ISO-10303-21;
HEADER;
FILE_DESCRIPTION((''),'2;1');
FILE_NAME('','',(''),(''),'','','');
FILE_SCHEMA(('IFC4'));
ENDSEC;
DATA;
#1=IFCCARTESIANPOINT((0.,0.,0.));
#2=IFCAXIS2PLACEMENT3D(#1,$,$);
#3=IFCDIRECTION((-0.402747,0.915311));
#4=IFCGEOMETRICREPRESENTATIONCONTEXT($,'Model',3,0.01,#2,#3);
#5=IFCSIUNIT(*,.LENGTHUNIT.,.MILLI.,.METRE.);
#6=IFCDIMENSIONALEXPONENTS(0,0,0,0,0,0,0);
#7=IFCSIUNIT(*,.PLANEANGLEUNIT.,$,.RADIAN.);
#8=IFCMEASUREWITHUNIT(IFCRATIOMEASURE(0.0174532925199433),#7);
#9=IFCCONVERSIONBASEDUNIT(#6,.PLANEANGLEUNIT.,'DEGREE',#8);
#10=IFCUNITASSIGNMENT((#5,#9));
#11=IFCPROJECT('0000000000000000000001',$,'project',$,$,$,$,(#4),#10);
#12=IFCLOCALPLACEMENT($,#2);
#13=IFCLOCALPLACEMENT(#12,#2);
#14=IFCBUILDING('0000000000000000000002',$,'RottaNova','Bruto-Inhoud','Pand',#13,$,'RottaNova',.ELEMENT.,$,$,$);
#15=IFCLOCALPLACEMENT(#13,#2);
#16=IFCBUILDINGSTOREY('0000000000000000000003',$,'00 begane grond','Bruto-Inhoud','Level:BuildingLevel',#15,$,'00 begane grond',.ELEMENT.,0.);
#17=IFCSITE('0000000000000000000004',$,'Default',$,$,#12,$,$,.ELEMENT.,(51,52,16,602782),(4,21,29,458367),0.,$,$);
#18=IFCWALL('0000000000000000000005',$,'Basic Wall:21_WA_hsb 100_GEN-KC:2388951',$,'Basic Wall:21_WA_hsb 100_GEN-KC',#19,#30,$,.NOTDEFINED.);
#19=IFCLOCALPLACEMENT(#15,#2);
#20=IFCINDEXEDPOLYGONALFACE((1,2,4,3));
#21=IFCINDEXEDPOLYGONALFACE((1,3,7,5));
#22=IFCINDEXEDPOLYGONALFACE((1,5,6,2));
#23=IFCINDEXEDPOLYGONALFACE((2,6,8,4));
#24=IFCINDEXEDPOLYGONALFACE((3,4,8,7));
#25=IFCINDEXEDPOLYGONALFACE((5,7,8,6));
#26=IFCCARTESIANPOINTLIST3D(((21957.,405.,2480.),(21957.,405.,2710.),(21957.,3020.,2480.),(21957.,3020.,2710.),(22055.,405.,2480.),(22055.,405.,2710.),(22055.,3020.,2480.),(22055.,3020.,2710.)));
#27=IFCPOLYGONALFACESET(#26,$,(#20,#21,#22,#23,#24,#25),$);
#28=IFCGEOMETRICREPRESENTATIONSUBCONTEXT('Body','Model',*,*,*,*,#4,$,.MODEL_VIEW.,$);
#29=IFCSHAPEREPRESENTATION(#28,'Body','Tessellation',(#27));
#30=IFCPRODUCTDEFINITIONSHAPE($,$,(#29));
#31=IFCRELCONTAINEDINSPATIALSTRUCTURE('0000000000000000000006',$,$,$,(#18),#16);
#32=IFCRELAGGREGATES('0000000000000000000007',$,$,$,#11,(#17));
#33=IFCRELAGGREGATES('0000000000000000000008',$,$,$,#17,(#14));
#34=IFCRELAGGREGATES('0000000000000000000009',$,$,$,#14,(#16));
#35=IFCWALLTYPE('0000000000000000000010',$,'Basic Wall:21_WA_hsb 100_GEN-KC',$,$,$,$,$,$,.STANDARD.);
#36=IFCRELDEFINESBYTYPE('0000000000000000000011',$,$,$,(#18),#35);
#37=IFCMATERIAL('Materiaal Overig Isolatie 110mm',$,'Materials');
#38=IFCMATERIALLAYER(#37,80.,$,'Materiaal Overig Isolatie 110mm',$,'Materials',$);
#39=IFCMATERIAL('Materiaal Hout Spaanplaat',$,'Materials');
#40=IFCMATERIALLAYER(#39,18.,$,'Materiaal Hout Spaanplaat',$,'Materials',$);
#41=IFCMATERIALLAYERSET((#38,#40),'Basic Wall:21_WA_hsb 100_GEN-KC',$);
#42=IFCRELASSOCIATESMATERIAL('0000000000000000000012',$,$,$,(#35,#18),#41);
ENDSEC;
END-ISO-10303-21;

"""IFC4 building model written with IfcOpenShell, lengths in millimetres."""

from ifc_helpers import new_model, entity, si_unit, converted_unit, direction, frame, frame_2d, origin, place, context, subcontext, project, spatial, rectangle, extrude, material, layer, layer_set, type_object, element, save


model = new_model("IFC4")

# Units and contexts
model_context = context("Model", 3, precision=0.01, world=origin(), true_north=direction((-0.402747, 0.915311)))
body_context = subcontext(model_context, "Body", "Model", "MODEL_VIEW")
ifc_project = project(units=[si_unit("LENGTHUNIT", "METRE", prefix="MILLI"), converted_unit("PLANEANGLEUNIT", "DEGREE", entity("IfcRatioMeasure", 0.0174532925199433), si_unit("PLANEANGLEUNIT", "RADIAN"), dimensions=[0, 0, 0, 0, 0, 0, 0])], contexts=[model_context])

# Site, building, storey
site_placement = place(None, origin())
site = spatial("IfcSite", under=ifc_project, at=site_placement, Name="Default", CompositionType="ELEMENT", RefLatitude=(51, 52, 16, 602782), RefLongitude=(4, 21, 29, 458367), RefElevation=0.0)
building_placement = place(site_placement, origin())
building = spatial("IfcBuilding", under=site, at=building_placement, Name="RottaNova", Description="Bruto-Inhoud", ObjectType="Pand", LongName="RottaNova", CompositionType="ELEMENT")
storey_placement = place(building_placement, origin())
storey = spatial("IfcBuildingStorey", under=building, at=storey_placement, Name="00 begane grond", Description="Bruto-Inhoud", ObjectType="Level:BuildingLevel", LongName="00 begane grond", CompositionType="ELEMENT", Elevation=0.0)

# Wall
ifc_material_1 = material(Name="Materiaal Overig Isolatie 110mm", Category="Materials")
ifc_layer_1 = layer(ifc_material_1, 80.0, Name="Materiaal Overig Isolatie 110mm", Category="Materials")
ifc_material_2 = material(Name="Materiaal Hout Spaanplaat", Category="Materials")
ifc_layer_2 = layer(ifc_material_2, 18.0, Name="Materiaal Hout Spaanplaat", Category="Materials")
ifc_layer_set_1 = layer_set([ifc_layer_1, ifc_layer_2], Name="Basic Wall:21_WA_hsb 100_GEN-KC")
wall_type_1 = type_object("IfcWallType", Name="Basic Wall:21_WA_hsb 100_GEN-KC", PredefinedType="STANDARD", material=ifc_layer_set_1)
wall_1_placement = place(storey_placement, frame((22006.0, 3020.0, 2480.0), z_axis=(0.0, 0.0, 1.0), x_axis=(0.0, -1.0, 0.0)))
element("IfcWall", 1, at=wall_1_placement, inside=storey, type_object=wall_type_1, material=ifc_layer_set_1, Name="Basic Wall:21_WA_hsb 100_GEN-KC:2388951", ObjectType="Basic Wall:21_WA_hsb 100_GEN-KC", PredefinedType="NOTDEFINED", context=body_context, shape_type="SweptSolid", body=[
    extrude(rectangle(XDim=2615.0, YDim=98.0, at=frame_2d((1307.5, 0.0), x_axis=(-1.0, 0.0))), origin(), (0.0, 0.0, 1.0), 230.0),
])

save(model, "model.ifc")
